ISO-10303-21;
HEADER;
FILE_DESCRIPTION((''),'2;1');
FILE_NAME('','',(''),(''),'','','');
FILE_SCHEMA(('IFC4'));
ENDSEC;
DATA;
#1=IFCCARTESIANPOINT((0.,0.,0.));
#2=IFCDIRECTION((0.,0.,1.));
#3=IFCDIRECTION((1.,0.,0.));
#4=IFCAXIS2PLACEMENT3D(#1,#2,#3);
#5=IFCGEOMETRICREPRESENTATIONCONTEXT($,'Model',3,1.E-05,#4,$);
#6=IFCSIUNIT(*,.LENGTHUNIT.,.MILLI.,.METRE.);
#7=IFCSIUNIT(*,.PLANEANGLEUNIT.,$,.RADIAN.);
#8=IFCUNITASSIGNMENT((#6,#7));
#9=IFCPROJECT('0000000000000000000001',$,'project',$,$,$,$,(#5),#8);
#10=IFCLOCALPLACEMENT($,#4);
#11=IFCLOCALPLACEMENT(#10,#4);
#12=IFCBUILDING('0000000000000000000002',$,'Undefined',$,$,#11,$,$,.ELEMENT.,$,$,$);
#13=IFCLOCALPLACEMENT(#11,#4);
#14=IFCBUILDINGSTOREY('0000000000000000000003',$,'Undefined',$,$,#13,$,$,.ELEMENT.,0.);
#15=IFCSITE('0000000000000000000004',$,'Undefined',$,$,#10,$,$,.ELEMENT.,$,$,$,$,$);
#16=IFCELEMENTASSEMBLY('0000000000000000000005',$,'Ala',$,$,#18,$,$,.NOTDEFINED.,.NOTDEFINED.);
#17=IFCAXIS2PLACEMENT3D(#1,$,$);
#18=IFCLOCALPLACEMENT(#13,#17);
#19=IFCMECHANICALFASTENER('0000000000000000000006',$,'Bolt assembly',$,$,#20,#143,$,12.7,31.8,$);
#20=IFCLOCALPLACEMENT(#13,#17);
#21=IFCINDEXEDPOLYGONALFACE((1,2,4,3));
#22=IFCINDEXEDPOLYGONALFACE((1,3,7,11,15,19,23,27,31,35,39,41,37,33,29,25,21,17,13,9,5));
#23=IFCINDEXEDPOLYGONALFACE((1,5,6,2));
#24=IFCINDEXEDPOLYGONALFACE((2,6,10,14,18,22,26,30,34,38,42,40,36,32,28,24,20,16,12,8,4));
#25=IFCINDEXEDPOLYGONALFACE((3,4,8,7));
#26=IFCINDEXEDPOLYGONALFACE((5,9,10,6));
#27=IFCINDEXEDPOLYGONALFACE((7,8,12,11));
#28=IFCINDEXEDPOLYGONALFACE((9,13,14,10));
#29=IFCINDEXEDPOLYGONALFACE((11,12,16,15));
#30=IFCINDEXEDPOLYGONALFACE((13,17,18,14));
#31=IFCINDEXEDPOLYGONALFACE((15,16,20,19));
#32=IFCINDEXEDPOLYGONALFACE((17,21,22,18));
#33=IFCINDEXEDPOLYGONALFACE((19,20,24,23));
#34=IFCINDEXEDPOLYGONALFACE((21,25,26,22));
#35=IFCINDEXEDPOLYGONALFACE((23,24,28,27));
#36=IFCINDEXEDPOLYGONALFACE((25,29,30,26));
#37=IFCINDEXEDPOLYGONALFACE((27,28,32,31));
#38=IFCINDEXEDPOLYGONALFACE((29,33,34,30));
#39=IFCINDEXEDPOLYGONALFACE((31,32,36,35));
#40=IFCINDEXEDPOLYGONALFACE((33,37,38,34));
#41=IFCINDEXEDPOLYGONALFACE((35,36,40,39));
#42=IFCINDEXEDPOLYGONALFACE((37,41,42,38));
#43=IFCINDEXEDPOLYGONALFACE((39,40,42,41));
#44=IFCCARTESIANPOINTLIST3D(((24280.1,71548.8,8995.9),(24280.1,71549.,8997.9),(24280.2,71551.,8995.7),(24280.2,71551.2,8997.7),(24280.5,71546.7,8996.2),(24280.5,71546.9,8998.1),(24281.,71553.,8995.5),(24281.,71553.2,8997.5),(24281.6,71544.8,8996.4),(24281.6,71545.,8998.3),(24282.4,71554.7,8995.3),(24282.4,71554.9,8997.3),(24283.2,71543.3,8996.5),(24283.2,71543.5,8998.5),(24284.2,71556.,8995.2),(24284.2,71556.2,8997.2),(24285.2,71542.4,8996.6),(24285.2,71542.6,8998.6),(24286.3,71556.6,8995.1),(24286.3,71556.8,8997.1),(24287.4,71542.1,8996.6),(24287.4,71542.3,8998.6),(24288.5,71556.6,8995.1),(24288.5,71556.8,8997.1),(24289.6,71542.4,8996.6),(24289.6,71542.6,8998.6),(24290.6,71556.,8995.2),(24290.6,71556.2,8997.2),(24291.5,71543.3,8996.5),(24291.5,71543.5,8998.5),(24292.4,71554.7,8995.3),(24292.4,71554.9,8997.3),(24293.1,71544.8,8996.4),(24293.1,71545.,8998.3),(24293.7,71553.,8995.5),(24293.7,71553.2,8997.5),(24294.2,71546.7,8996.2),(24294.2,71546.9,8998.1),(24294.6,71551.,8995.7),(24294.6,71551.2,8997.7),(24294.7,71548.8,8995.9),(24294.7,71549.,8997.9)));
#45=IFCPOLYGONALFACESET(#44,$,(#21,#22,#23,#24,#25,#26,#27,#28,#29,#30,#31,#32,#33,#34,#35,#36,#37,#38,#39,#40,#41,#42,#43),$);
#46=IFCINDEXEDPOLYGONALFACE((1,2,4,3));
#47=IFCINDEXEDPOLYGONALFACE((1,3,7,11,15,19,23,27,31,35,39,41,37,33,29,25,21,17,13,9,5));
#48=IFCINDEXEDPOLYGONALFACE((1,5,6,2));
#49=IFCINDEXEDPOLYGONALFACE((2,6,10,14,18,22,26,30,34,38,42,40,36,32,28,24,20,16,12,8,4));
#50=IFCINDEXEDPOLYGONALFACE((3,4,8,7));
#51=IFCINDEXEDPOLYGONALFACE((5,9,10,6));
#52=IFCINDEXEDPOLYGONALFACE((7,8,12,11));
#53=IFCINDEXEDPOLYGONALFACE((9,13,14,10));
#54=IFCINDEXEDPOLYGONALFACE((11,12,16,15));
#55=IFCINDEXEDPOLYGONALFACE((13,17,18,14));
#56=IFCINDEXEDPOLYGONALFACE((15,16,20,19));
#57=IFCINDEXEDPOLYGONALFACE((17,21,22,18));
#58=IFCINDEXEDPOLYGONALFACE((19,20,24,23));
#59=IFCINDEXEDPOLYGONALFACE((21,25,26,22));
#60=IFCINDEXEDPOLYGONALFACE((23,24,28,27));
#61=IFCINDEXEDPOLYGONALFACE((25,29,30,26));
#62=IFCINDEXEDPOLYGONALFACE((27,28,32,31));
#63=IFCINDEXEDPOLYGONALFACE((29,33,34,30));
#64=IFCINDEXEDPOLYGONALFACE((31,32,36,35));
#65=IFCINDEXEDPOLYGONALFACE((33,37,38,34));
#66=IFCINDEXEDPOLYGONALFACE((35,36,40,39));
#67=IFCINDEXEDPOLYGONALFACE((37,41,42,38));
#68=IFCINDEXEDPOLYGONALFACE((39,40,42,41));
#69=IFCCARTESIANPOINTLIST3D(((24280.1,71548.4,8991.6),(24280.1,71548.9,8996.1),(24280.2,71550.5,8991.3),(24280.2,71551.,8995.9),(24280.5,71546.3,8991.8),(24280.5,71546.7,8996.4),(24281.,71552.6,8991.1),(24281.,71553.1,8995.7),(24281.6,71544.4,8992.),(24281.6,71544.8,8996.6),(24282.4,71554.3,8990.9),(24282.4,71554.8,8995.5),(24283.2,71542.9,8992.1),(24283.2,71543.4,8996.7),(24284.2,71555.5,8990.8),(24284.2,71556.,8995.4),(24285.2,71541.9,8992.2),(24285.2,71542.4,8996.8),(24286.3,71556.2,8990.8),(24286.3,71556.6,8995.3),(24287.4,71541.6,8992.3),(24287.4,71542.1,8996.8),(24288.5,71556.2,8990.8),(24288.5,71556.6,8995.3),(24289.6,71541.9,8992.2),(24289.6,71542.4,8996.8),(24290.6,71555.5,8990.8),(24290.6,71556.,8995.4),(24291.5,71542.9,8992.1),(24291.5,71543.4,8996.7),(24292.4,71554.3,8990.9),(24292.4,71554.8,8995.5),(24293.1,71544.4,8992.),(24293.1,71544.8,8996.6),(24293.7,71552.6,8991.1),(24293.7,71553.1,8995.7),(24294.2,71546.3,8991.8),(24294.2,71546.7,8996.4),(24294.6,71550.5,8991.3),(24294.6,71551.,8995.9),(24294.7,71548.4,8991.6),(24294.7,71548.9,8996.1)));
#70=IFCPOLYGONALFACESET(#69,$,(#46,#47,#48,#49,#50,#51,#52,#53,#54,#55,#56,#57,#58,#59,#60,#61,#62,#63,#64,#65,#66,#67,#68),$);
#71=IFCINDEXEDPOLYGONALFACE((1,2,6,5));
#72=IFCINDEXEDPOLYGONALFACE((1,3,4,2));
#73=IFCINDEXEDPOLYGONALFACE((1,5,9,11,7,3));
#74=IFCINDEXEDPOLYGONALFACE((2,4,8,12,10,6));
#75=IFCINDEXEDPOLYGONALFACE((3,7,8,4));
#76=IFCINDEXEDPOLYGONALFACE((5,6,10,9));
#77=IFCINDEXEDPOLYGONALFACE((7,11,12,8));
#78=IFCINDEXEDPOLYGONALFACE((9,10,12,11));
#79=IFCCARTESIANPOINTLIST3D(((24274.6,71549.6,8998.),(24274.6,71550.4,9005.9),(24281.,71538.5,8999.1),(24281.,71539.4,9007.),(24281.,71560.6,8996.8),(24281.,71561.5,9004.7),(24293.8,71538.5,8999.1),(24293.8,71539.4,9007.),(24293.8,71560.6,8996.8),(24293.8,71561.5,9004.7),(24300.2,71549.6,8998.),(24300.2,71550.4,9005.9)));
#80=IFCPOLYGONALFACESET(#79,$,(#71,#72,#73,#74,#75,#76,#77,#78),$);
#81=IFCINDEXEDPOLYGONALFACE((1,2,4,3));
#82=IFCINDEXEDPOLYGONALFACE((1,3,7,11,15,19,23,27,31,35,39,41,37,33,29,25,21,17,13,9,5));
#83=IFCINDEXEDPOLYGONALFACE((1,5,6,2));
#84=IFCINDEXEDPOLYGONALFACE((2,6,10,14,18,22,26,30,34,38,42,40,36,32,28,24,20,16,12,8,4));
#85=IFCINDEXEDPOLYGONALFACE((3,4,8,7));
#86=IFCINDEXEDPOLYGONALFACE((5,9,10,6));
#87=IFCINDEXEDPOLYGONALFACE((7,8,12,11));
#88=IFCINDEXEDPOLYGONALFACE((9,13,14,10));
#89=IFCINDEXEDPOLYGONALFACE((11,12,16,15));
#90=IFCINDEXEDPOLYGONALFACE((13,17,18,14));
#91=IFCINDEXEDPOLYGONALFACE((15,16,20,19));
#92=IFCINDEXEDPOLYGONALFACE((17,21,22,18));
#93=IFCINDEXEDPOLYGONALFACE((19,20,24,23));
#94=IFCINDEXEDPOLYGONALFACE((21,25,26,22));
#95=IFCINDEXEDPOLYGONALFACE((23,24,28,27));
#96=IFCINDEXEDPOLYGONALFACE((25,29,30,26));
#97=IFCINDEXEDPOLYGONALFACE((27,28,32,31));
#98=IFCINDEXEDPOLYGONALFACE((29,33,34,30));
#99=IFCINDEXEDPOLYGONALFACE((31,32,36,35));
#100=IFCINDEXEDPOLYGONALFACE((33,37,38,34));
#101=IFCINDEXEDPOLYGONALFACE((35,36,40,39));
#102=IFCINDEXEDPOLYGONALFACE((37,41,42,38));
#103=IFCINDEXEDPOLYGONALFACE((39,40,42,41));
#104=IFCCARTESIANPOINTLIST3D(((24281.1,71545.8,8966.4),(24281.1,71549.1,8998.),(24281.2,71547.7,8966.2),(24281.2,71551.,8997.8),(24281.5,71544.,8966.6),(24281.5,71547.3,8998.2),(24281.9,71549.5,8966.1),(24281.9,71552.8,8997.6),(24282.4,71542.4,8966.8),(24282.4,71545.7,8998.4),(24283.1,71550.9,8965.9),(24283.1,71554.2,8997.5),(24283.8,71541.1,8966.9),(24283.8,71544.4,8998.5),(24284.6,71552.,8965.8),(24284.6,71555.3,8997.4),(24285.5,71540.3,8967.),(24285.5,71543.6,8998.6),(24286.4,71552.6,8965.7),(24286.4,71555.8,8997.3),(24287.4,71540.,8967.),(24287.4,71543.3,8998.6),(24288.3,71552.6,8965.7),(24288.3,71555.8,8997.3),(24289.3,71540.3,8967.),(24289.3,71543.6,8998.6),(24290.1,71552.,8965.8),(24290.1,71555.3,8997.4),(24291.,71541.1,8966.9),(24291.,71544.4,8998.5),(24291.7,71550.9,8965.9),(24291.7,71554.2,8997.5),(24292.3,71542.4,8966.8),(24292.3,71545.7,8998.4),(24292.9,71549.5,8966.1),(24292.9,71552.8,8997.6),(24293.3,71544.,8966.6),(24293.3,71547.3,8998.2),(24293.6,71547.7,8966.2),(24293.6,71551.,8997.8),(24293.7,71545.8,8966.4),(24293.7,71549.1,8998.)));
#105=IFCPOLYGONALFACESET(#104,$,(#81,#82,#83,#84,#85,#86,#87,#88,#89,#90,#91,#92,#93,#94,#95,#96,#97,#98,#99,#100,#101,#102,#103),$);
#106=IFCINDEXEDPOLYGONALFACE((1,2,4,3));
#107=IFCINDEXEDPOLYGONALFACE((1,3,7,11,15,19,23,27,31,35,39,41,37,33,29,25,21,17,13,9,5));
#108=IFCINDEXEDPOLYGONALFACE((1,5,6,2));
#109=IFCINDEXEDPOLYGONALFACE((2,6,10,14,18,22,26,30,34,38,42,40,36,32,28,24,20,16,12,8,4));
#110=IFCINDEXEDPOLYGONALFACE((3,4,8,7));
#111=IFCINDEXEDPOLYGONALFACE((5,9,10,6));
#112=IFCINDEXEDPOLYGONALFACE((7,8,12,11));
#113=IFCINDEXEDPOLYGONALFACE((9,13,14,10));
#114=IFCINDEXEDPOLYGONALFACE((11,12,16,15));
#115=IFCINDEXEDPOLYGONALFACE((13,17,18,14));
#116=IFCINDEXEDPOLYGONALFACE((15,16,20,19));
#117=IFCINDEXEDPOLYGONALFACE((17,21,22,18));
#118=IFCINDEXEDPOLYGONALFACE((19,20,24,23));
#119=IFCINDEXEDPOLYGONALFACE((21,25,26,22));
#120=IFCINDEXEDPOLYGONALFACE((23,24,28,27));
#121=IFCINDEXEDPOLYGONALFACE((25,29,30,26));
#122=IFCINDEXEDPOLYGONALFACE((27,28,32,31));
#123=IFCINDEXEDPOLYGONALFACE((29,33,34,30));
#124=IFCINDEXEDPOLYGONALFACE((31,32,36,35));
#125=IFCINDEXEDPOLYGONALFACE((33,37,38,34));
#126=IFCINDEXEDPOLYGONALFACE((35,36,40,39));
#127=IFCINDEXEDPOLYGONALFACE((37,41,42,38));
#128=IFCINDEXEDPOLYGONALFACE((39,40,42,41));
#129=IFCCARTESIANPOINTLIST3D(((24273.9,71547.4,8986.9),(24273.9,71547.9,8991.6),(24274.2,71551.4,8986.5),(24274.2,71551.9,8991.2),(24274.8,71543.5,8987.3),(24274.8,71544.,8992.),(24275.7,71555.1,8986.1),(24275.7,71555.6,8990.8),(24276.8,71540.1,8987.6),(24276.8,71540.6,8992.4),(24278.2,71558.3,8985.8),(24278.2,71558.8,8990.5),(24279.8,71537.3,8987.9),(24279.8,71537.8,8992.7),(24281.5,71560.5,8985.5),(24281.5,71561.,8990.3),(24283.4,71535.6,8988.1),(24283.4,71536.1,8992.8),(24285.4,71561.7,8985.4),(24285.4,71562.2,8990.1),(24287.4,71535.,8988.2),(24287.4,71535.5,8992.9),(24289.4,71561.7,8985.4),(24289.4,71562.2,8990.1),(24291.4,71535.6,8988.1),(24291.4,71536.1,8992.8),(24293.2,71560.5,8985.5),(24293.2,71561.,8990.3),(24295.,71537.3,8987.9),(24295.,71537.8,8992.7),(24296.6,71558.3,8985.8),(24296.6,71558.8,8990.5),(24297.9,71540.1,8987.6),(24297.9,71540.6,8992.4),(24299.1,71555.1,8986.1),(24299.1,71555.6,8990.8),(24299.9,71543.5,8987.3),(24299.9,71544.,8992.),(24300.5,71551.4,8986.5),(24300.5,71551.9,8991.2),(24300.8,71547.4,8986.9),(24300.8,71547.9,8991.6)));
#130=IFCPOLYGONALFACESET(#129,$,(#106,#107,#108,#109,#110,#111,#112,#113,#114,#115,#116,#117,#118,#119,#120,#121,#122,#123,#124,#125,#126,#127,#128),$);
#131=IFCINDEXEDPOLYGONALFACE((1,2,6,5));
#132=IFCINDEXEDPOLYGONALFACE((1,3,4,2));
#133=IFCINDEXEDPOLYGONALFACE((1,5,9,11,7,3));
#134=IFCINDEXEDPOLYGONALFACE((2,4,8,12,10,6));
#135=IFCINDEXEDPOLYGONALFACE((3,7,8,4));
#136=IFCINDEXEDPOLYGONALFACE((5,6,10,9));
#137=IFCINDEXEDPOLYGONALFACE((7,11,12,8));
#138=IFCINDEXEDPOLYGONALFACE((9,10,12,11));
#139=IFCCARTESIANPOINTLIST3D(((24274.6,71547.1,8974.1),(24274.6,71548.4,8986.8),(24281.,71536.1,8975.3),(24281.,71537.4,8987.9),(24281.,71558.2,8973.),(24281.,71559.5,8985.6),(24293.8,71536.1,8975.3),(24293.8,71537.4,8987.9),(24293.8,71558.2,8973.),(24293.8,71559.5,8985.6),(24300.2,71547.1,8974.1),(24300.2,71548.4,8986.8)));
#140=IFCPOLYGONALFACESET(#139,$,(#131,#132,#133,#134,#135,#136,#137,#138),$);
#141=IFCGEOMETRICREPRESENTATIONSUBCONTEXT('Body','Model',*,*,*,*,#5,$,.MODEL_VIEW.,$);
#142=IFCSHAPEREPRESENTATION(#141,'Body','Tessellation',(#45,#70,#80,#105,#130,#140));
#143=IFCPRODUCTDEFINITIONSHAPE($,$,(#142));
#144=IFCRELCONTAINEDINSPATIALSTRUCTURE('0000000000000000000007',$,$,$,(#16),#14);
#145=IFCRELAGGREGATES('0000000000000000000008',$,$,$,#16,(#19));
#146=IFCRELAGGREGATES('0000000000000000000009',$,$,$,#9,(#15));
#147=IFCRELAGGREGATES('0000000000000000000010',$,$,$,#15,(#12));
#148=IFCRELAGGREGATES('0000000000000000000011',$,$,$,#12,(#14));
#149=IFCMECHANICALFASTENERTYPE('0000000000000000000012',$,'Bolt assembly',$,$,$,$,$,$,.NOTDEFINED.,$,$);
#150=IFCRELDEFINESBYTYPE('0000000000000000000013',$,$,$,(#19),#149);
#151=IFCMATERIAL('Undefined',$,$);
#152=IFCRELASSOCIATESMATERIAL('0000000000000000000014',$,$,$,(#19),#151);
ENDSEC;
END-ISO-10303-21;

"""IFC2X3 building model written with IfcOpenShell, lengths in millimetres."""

from ifc_helpers import new_model, si_unit, frame, origin_with_axes, origin_2d_with_axis, place, context, subcontext, project, spatial, polyline, circle, outline, extrude, source, transform, mapped, material, type_object, element, aggregate, save


model = new_model("IFC2X3")

# Units and contexts
model_context = context("Model", 3, precision=1e-05, world=origin_with_axes())
body_context = subcontext(model_context, "Body", "Model", "MODEL_VIEW")
ifc_project = project(units=[si_unit("LENGTHUNIT", "METRE", prefix="MILLI"), si_unit("PLANEANGLEUNIT", "RADIAN")], contexts=[model_context])

# Site, building, storey
site_placement = place(None, origin_with_axes())
site = spatial("IfcSite", under=ifc_project, at=site_placement, Name="Undefined", CompositionType="ELEMENT")
building_placement = place(site_placement, origin_with_axes())
building = spatial("IfcBuilding", under=site, at=building_placement, Name="Undefined", CompositionType="ELEMENT")
storey_placement = place(building_placement, origin_with_axes())
storey = spatial("IfcBuildingStorey", under=building, at=storey_placement, Name="Undefined", CompositionType="ELEMENT", Elevation=0.0)

# Shared definitions
ifc_material_1 = material(Name="Undefined")
mechanical_fastener_type = type_object("IfcMechanicalFastenerType", Name="Bolt assembly")

# Shared definitions
shared_shape_1 = source(origin_with_axes(), body_context, "Body", "SweptSolid", [
    extrude(circle(Radius=7.3, at=origin_2d_with_axis()), frame((0.0, -1.9, 0.0), z_axis=(0.0, 1.0, 0.0), x_axis=(1.0, 0.0, 0.0)), (0.0, 0.0, 1.0), 2.0),
    extrude(circle(Radius=7.3, at=origin_2d_with_axis()), frame((0.0, -0.1, 0.0), z_axis=(0.0, 1.0, 0.0), x_axis=(1.0, 0.0, 0.0)), (0.0, 0.0, 1.0), 4.6),
    extrude(outline(polyline([(11.1, -6.4), (11.1, 6.4), (0.0, 12.8), (-11.1, 6.4), (-11.1, -6.4), (0.0, -12.8), (11.1, -6.4)])), frame((0.0, -9.9, 0.0), z_axis=(0.0, 1.0, 0.0), x_axis=(1.0, 0.0, 0.0)), (0.0, 0.0, 1.0), 7.9),
    extrude(circle(Radius=6.3, at=origin_2d_with_axis()), frame((0.0, -2.0, 0.0), z_axis=(0.0, 1.0, 0.0), x_axis=(1.0, 0.0, 0.0)), (0.0, 0.0, 1.0), 31.8),
    extrude(circle(Radius=13.5, at=origin_2d_with_axis()), frame((0.0, 4.5, 0.0), z_axis=(0.0, 1.0, 0.0), x_axis=(1.0, 0.0, 0.0)), (0.0, 0.0, 1.0), 4.8),
    extrude(outline(polyline([(11.1, -6.4), (11.1, 6.4), (0.0, 12.8), (-11.1, 6.4), (-11.1, -6.4), (0.0, -12.8), (11.1, -6.4)])), frame((0.0, 9.3, 0.0), z_axis=(0.0, 1.0, 0.0), x_axis=(1.0, 0.0, 0.0)), (0.0, 0.0, 1.0), 12.7),
])

# Element assembly, mechanical fastener
assembly_1_placement = place(storey_placement, origin_with_axes())
assembly_1 = element("IfcElementAssembly", 1, at=assembly_1_placement, inside=storey, Name="Ala", AssemblyPlace="NOTDEFINED", PredefinedType="NOTDEFINED")
mechanical_fastener_1_placement = place(assembly_1_placement, frame((24287.4, 71549.4, 8996.0), z_axis=(1.0, 0.0, 0.0), x_axis=(0.0, -0.994665, 0.103162)))
mechanical_fastener_1 = element("IfcMechanicalFastener", 2, at=mechanical_fastener_1_placement, type_object=mechanical_fastener_type, material=ifc_material_1, Name="Bolt assembly", NominalDiameter=12.7, NominalLength=31.8, context=body_context, shape_type="MappedRepresentation", body=[
    mapped(shared_shape_1, transform((0.0, 0.0, 0.0))),
])
aggregate(assembly_1, [mechanical_fastener_1])

save(model, "model.ifc")
